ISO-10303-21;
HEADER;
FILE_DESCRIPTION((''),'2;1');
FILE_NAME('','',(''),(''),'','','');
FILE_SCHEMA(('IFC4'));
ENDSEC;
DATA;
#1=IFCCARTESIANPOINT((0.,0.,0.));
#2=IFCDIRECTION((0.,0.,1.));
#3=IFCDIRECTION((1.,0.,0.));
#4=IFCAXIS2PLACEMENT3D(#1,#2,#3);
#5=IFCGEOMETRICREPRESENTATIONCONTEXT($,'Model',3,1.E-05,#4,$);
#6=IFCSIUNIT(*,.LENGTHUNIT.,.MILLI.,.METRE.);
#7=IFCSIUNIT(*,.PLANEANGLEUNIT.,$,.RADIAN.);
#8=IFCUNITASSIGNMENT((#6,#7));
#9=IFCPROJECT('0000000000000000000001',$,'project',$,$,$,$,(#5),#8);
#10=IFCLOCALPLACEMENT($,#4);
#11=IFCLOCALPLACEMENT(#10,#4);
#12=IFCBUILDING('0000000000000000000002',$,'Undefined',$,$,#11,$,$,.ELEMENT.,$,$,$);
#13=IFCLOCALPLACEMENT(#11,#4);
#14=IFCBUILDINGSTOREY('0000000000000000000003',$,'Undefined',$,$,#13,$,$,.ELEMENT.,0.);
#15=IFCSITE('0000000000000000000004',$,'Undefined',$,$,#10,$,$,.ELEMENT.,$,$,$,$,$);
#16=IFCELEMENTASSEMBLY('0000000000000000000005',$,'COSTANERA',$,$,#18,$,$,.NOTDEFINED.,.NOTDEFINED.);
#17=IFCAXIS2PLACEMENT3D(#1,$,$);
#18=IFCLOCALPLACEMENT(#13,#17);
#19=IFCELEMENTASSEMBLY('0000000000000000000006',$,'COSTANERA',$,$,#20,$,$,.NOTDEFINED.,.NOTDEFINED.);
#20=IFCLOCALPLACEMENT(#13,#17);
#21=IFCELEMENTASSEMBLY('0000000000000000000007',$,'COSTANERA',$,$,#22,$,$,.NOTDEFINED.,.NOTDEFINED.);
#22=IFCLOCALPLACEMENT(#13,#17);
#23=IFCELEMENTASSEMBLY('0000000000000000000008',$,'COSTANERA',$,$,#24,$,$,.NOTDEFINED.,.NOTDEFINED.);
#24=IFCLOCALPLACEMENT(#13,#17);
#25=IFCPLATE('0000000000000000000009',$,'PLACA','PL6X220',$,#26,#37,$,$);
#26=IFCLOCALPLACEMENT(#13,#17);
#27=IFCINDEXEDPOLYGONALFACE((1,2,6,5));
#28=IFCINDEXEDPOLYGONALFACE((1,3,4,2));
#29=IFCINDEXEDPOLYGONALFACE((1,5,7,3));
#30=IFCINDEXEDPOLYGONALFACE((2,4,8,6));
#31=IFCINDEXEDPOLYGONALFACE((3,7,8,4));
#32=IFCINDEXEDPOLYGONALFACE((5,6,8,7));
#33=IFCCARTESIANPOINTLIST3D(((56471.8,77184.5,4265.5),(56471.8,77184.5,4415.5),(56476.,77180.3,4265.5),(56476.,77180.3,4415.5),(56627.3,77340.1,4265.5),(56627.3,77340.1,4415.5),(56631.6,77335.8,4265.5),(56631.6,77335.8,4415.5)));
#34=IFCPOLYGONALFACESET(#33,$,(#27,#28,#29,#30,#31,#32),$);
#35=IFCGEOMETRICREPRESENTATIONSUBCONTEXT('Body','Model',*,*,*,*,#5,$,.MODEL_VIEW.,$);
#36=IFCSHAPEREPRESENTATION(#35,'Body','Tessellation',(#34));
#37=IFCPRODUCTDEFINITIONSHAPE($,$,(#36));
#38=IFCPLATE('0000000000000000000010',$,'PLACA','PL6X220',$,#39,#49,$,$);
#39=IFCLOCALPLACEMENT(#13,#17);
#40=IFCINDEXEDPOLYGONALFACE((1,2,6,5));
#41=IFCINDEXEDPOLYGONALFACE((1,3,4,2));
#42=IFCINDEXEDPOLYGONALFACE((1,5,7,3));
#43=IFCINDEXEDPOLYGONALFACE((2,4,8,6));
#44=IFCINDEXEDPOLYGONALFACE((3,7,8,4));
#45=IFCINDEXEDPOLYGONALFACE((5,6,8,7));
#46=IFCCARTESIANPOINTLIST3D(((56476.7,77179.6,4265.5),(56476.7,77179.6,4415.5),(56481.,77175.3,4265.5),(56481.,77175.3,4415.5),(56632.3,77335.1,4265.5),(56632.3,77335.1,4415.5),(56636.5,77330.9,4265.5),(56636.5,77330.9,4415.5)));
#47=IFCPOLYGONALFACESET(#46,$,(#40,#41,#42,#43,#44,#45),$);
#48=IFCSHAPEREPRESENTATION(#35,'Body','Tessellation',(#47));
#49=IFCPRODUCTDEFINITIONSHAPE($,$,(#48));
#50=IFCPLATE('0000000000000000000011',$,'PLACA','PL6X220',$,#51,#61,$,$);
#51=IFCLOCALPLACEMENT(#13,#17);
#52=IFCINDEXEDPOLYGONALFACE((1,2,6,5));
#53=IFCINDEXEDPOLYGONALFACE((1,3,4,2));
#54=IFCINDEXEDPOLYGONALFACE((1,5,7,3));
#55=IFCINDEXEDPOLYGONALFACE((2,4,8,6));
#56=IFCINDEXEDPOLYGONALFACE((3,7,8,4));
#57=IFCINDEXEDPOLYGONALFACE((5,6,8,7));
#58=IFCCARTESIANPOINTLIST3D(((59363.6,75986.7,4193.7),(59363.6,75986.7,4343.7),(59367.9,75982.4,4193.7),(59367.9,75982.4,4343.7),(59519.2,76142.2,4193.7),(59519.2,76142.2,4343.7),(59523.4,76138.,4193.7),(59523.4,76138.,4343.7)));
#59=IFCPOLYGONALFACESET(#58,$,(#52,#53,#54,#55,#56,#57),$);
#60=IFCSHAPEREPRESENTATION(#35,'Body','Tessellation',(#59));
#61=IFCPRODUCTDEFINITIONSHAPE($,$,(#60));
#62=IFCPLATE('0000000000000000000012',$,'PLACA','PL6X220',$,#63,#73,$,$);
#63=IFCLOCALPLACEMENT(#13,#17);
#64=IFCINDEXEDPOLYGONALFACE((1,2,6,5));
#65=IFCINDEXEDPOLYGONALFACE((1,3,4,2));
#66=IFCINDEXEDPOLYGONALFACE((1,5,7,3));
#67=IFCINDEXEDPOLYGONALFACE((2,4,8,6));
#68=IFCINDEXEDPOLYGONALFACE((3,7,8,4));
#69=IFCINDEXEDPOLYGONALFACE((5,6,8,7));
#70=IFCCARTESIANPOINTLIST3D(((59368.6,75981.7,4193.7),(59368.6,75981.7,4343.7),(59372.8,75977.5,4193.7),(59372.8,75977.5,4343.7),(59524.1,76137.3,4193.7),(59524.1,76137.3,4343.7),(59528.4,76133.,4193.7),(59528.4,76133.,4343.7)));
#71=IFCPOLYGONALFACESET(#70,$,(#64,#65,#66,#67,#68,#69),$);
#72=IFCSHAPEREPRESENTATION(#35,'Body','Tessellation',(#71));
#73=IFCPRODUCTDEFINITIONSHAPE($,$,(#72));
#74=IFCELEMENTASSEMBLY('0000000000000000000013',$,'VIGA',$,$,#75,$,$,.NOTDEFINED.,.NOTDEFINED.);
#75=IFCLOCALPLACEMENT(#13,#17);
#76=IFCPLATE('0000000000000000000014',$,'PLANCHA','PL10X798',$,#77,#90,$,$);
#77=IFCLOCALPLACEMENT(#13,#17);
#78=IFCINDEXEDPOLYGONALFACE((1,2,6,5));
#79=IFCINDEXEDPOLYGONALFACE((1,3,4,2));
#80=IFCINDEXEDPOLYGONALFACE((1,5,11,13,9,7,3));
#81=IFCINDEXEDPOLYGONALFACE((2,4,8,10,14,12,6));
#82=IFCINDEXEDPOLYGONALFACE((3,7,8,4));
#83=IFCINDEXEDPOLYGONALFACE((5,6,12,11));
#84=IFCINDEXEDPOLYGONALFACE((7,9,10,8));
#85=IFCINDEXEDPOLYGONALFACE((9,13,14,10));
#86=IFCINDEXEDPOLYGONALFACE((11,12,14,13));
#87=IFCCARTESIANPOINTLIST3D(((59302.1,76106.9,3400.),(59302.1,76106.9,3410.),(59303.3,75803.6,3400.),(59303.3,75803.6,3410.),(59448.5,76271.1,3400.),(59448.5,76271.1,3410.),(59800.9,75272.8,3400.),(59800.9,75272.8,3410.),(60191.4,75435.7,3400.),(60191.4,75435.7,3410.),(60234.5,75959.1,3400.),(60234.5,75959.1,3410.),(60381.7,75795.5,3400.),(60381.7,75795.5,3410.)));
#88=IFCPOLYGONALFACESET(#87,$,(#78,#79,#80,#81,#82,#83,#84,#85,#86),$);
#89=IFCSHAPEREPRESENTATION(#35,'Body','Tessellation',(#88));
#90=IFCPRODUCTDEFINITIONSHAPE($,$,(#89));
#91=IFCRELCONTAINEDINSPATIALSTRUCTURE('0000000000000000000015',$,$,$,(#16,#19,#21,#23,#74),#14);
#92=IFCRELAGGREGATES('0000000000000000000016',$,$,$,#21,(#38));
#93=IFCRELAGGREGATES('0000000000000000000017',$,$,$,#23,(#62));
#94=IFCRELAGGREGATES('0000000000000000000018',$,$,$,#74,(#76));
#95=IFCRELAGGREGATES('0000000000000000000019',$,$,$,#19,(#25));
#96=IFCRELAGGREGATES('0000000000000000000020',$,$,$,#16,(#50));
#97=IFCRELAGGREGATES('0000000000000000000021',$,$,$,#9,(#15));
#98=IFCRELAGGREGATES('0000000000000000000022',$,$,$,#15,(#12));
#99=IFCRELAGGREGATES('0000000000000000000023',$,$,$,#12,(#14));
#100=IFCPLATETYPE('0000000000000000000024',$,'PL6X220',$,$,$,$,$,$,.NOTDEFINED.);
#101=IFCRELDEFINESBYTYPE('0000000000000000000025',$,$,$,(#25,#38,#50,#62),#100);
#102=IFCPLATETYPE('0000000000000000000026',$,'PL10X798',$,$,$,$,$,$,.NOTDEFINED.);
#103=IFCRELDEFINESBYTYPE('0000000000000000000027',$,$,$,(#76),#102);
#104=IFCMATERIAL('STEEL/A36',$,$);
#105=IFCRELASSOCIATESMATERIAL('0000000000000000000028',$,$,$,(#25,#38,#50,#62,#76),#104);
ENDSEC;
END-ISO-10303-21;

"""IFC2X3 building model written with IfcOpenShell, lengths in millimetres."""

from ifc_helpers import new_model, si_unit, frame, origin_with_axes, place, context, subcontext, project, spatial, polyline, outline, extrude, material, type_object, element, aggregate, save


model = new_model("IFC2X3")

# Units and contexts
model_context = context("Model", 3, precision=1e-05, world=origin_with_axes())
body_context = subcontext(model_context, "Body", "Model", "MODEL_VIEW")
ifc_project = project(units=[si_unit("LENGTHUNIT", "METRE", prefix="MILLI"), si_unit("PLANEANGLEUNIT", "RADIAN")], contexts=[model_context])

# Site, building, storey
site_placement = place(None, origin_with_axes())
site = spatial("IfcSite", under=ifc_project, at=site_placement, Name="Undefined", CompositionType="ELEMENT")
building_placement = place(site_placement, origin_with_axes())
building = spatial("IfcBuilding", under=site, at=building_placement, Name="Undefined", CompositionType="ELEMENT")
storey_placement = place(building_placement, origin_with_axes())
storey = spatial("IfcBuildingStorey", under=building, at=storey_placement, Name="Undefined", CompositionType="ELEMENT", Elevation=0.0)

# Element assemblies
assembly_1_placement = place(storey_placement, origin_with_axes())
assembly_1 = element("IfcElementAssembly", 1, at=assembly_1_placement, inside=storey, Name="COSTANERA", AssemblyPlace="NOTDEFINED", PredefinedType="NOTDEFINED")
ifc_material_1 = material(Name="STEEL/A36")
assembly_2_placement = place(storey_placement, origin_with_axes())
assembly_2 = element("IfcElementAssembly", 2, at=assembly_2_placement, inside=storey, Name="COSTANERA", AssemblyPlace="NOTDEFINED", PredefinedType="NOTDEFINED")
assembly_3_placement = place(storey_placement, origin_with_axes())
assembly_3 = element("IfcElementAssembly", 3, at=assembly_3_placement, inside=storey, Name="COSTANERA", AssemblyPlace="NOTDEFINED", PredefinedType="NOTDEFINED")
assembly_4_placement = place(storey_placement, origin_with_axes())
assembly_4 = element("IfcElementAssembly", 4, at=assembly_4_placement, inside=storey, Name="COSTANERA", AssemblyPlace="NOTDEFINED", PredefinedType="NOTDEFINED")

# Plates
plate_type_1 = type_object("IfcPlateType", Name="PL6X220", PredefinedType="NOTDEFINED")
plate_1_placement = place(assembly_2_placement, frame((56551.7, 77260.2, 4265.5), z_axis=(-0.707107, 0.707107, 0.0), x_axis=(0.0, 0.0, 1.0)))
plate_1 = element("IfcPlate", 5, at=plate_1_placement, type_object=plate_type_1, material=ifc_material_1, Name="PLACA", Description="PL6X220", context=body_context, shape_type="SweptSolid", body=[
    extrude(outline(polyline([(0.0, -110.0), (0.0, 110.0), (150.0, 110.0), (150.0, -110.0), (0.0, -110.0)])), frame((0.0, 0.0, -3.0), z_axis=(0.0, 0.0, 1.0), x_axis=(1.0, 0.0, 0.0)), (0.0, 0.0, 1.0), 6.0),
])
plate_2_placement = place(assembly_3_placement, frame((56556.6, 77255.2, 4265.5), z_axis=(-0.707107, 0.707107, 0.0), x_axis=(0.0, 0.0, 1.0)))
plate_2 = element("IfcPlate", 6, at=plate_2_placement, type_object=plate_type_1, material=ifc_material_1, Name="PLACA", Description="PL6X220", context=body_context, shape_type="SweptSolid", body=[
    extrude(outline(polyline([(0.0, -110.0), (0.0, 110.0), (150.0, 110.0), (150.0, -110.0), (0.0, -110.0)])), frame((0.0, 0.0, -3.0), z_axis=(0.0, 0.0, 1.0), x_axis=(1.0, 0.0, 0.0)), (0.0, 0.0, 1.0), 6.0),
])
aggregate(assembly_3, [plate_2])
plate_3_placement = place(assembly_1_placement, frame((59443.5, 76062.3, 4193.7), z_axis=(-0.707107, 0.707107, 0.0), x_axis=(0.0, 0.0, 1.0)))
plate_3 = element("IfcPlate", 7, at=plate_3_placement, type_object=plate_type_1, material=ifc_material_1, Name="PLACA", Description="PL6X220", context=body_context, shape_type="SweptSolid", body=[
    extrude(outline(polyline([(0.0, -110.0), (0.0, 110.0), (150.0, 110.0), (150.0, -110.0), (0.0, -110.0)])), frame((0.0, 0.0, -3.0), z_axis=(0.0, 0.0, 1.0), x_axis=(1.0, 0.0, 0.0)), (0.0, 0.0, 1.0), 6.0),
])
plate_4_placement = place(assembly_4_placement, frame((59448.5, 76057.4, 4193.7), z_axis=(-0.707107, 0.707107, 0.0), x_axis=(0.0, 0.0, 1.0)))
plate_4 = element("IfcPlate", 8, at=plate_4_placement, type_object=plate_type_1, material=ifc_material_1, Name="PLACA", Description="PL6X220", context=body_context, shape_type="SweptSolid", body=[
    extrude(outline(polyline([(0.0, -110.0), (0.0, 110.0), (150.0, 110.0), (150.0, -110.0), (0.0, -110.0)])), frame((0.0, 0.0, -3.0), z_axis=(0.0, 0.0, 1.0), x_axis=(1.0, 0.0, 0.0)), (0.0, 0.0, 1.0), 6.0),
])
aggregate(assembly_4, [plate_4])

# Element assembly, plate
assembly_5_placement = place(storey_placement, origin_with_axes())
assembly_5 = element("IfcElementAssembly", 9, at=assembly_5_placement, inside=storey, Name="VIGA", AssemblyPlace="NOTDEFINED", PredefinedType="NOTDEFINED")
plate_type_2 = type_object("IfcPlateType", Name="PL10X798", PredefinedType="NOTDEFINED")
plate_5_placement = place(assembly_5_placement, frame((60191.4, 75435.7, 3405.0), z_axis=(0.0, 0.0, -1.0), x_axis=(-0.922915, -0.385004, 0.0)))
plate_5 = element("IfcPlate", 10, at=plate_5_placement, type_object=plate_type_2, material=ifc_material_1, Name="PLANCHA", Description="PL10X798", context=body_context, shape_type="SweptSolid", body=[
    extrude(outline(polyline([(0.0, 0.0), (423.2, 0.0), (678.0, 681.5), (562.4, 961.8), (364.0, 1057.0), (-241.2, 466.4), (-314.1, 258.8), (0.0, 0.0)])), frame((0.0, 0.0, -5.0), z_axis=(0.0, 0.0, 1.0), x_axis=(1.0, 0.0, 0.0)), (0.0, 0.0, 1.0), 10.0),
])
aggregate(assembly_5, [plate_5])

aggregate(assembly_2, [plate_1])
aggregate(assembly_1, [plate_3])

save(model, "model.ifc")
